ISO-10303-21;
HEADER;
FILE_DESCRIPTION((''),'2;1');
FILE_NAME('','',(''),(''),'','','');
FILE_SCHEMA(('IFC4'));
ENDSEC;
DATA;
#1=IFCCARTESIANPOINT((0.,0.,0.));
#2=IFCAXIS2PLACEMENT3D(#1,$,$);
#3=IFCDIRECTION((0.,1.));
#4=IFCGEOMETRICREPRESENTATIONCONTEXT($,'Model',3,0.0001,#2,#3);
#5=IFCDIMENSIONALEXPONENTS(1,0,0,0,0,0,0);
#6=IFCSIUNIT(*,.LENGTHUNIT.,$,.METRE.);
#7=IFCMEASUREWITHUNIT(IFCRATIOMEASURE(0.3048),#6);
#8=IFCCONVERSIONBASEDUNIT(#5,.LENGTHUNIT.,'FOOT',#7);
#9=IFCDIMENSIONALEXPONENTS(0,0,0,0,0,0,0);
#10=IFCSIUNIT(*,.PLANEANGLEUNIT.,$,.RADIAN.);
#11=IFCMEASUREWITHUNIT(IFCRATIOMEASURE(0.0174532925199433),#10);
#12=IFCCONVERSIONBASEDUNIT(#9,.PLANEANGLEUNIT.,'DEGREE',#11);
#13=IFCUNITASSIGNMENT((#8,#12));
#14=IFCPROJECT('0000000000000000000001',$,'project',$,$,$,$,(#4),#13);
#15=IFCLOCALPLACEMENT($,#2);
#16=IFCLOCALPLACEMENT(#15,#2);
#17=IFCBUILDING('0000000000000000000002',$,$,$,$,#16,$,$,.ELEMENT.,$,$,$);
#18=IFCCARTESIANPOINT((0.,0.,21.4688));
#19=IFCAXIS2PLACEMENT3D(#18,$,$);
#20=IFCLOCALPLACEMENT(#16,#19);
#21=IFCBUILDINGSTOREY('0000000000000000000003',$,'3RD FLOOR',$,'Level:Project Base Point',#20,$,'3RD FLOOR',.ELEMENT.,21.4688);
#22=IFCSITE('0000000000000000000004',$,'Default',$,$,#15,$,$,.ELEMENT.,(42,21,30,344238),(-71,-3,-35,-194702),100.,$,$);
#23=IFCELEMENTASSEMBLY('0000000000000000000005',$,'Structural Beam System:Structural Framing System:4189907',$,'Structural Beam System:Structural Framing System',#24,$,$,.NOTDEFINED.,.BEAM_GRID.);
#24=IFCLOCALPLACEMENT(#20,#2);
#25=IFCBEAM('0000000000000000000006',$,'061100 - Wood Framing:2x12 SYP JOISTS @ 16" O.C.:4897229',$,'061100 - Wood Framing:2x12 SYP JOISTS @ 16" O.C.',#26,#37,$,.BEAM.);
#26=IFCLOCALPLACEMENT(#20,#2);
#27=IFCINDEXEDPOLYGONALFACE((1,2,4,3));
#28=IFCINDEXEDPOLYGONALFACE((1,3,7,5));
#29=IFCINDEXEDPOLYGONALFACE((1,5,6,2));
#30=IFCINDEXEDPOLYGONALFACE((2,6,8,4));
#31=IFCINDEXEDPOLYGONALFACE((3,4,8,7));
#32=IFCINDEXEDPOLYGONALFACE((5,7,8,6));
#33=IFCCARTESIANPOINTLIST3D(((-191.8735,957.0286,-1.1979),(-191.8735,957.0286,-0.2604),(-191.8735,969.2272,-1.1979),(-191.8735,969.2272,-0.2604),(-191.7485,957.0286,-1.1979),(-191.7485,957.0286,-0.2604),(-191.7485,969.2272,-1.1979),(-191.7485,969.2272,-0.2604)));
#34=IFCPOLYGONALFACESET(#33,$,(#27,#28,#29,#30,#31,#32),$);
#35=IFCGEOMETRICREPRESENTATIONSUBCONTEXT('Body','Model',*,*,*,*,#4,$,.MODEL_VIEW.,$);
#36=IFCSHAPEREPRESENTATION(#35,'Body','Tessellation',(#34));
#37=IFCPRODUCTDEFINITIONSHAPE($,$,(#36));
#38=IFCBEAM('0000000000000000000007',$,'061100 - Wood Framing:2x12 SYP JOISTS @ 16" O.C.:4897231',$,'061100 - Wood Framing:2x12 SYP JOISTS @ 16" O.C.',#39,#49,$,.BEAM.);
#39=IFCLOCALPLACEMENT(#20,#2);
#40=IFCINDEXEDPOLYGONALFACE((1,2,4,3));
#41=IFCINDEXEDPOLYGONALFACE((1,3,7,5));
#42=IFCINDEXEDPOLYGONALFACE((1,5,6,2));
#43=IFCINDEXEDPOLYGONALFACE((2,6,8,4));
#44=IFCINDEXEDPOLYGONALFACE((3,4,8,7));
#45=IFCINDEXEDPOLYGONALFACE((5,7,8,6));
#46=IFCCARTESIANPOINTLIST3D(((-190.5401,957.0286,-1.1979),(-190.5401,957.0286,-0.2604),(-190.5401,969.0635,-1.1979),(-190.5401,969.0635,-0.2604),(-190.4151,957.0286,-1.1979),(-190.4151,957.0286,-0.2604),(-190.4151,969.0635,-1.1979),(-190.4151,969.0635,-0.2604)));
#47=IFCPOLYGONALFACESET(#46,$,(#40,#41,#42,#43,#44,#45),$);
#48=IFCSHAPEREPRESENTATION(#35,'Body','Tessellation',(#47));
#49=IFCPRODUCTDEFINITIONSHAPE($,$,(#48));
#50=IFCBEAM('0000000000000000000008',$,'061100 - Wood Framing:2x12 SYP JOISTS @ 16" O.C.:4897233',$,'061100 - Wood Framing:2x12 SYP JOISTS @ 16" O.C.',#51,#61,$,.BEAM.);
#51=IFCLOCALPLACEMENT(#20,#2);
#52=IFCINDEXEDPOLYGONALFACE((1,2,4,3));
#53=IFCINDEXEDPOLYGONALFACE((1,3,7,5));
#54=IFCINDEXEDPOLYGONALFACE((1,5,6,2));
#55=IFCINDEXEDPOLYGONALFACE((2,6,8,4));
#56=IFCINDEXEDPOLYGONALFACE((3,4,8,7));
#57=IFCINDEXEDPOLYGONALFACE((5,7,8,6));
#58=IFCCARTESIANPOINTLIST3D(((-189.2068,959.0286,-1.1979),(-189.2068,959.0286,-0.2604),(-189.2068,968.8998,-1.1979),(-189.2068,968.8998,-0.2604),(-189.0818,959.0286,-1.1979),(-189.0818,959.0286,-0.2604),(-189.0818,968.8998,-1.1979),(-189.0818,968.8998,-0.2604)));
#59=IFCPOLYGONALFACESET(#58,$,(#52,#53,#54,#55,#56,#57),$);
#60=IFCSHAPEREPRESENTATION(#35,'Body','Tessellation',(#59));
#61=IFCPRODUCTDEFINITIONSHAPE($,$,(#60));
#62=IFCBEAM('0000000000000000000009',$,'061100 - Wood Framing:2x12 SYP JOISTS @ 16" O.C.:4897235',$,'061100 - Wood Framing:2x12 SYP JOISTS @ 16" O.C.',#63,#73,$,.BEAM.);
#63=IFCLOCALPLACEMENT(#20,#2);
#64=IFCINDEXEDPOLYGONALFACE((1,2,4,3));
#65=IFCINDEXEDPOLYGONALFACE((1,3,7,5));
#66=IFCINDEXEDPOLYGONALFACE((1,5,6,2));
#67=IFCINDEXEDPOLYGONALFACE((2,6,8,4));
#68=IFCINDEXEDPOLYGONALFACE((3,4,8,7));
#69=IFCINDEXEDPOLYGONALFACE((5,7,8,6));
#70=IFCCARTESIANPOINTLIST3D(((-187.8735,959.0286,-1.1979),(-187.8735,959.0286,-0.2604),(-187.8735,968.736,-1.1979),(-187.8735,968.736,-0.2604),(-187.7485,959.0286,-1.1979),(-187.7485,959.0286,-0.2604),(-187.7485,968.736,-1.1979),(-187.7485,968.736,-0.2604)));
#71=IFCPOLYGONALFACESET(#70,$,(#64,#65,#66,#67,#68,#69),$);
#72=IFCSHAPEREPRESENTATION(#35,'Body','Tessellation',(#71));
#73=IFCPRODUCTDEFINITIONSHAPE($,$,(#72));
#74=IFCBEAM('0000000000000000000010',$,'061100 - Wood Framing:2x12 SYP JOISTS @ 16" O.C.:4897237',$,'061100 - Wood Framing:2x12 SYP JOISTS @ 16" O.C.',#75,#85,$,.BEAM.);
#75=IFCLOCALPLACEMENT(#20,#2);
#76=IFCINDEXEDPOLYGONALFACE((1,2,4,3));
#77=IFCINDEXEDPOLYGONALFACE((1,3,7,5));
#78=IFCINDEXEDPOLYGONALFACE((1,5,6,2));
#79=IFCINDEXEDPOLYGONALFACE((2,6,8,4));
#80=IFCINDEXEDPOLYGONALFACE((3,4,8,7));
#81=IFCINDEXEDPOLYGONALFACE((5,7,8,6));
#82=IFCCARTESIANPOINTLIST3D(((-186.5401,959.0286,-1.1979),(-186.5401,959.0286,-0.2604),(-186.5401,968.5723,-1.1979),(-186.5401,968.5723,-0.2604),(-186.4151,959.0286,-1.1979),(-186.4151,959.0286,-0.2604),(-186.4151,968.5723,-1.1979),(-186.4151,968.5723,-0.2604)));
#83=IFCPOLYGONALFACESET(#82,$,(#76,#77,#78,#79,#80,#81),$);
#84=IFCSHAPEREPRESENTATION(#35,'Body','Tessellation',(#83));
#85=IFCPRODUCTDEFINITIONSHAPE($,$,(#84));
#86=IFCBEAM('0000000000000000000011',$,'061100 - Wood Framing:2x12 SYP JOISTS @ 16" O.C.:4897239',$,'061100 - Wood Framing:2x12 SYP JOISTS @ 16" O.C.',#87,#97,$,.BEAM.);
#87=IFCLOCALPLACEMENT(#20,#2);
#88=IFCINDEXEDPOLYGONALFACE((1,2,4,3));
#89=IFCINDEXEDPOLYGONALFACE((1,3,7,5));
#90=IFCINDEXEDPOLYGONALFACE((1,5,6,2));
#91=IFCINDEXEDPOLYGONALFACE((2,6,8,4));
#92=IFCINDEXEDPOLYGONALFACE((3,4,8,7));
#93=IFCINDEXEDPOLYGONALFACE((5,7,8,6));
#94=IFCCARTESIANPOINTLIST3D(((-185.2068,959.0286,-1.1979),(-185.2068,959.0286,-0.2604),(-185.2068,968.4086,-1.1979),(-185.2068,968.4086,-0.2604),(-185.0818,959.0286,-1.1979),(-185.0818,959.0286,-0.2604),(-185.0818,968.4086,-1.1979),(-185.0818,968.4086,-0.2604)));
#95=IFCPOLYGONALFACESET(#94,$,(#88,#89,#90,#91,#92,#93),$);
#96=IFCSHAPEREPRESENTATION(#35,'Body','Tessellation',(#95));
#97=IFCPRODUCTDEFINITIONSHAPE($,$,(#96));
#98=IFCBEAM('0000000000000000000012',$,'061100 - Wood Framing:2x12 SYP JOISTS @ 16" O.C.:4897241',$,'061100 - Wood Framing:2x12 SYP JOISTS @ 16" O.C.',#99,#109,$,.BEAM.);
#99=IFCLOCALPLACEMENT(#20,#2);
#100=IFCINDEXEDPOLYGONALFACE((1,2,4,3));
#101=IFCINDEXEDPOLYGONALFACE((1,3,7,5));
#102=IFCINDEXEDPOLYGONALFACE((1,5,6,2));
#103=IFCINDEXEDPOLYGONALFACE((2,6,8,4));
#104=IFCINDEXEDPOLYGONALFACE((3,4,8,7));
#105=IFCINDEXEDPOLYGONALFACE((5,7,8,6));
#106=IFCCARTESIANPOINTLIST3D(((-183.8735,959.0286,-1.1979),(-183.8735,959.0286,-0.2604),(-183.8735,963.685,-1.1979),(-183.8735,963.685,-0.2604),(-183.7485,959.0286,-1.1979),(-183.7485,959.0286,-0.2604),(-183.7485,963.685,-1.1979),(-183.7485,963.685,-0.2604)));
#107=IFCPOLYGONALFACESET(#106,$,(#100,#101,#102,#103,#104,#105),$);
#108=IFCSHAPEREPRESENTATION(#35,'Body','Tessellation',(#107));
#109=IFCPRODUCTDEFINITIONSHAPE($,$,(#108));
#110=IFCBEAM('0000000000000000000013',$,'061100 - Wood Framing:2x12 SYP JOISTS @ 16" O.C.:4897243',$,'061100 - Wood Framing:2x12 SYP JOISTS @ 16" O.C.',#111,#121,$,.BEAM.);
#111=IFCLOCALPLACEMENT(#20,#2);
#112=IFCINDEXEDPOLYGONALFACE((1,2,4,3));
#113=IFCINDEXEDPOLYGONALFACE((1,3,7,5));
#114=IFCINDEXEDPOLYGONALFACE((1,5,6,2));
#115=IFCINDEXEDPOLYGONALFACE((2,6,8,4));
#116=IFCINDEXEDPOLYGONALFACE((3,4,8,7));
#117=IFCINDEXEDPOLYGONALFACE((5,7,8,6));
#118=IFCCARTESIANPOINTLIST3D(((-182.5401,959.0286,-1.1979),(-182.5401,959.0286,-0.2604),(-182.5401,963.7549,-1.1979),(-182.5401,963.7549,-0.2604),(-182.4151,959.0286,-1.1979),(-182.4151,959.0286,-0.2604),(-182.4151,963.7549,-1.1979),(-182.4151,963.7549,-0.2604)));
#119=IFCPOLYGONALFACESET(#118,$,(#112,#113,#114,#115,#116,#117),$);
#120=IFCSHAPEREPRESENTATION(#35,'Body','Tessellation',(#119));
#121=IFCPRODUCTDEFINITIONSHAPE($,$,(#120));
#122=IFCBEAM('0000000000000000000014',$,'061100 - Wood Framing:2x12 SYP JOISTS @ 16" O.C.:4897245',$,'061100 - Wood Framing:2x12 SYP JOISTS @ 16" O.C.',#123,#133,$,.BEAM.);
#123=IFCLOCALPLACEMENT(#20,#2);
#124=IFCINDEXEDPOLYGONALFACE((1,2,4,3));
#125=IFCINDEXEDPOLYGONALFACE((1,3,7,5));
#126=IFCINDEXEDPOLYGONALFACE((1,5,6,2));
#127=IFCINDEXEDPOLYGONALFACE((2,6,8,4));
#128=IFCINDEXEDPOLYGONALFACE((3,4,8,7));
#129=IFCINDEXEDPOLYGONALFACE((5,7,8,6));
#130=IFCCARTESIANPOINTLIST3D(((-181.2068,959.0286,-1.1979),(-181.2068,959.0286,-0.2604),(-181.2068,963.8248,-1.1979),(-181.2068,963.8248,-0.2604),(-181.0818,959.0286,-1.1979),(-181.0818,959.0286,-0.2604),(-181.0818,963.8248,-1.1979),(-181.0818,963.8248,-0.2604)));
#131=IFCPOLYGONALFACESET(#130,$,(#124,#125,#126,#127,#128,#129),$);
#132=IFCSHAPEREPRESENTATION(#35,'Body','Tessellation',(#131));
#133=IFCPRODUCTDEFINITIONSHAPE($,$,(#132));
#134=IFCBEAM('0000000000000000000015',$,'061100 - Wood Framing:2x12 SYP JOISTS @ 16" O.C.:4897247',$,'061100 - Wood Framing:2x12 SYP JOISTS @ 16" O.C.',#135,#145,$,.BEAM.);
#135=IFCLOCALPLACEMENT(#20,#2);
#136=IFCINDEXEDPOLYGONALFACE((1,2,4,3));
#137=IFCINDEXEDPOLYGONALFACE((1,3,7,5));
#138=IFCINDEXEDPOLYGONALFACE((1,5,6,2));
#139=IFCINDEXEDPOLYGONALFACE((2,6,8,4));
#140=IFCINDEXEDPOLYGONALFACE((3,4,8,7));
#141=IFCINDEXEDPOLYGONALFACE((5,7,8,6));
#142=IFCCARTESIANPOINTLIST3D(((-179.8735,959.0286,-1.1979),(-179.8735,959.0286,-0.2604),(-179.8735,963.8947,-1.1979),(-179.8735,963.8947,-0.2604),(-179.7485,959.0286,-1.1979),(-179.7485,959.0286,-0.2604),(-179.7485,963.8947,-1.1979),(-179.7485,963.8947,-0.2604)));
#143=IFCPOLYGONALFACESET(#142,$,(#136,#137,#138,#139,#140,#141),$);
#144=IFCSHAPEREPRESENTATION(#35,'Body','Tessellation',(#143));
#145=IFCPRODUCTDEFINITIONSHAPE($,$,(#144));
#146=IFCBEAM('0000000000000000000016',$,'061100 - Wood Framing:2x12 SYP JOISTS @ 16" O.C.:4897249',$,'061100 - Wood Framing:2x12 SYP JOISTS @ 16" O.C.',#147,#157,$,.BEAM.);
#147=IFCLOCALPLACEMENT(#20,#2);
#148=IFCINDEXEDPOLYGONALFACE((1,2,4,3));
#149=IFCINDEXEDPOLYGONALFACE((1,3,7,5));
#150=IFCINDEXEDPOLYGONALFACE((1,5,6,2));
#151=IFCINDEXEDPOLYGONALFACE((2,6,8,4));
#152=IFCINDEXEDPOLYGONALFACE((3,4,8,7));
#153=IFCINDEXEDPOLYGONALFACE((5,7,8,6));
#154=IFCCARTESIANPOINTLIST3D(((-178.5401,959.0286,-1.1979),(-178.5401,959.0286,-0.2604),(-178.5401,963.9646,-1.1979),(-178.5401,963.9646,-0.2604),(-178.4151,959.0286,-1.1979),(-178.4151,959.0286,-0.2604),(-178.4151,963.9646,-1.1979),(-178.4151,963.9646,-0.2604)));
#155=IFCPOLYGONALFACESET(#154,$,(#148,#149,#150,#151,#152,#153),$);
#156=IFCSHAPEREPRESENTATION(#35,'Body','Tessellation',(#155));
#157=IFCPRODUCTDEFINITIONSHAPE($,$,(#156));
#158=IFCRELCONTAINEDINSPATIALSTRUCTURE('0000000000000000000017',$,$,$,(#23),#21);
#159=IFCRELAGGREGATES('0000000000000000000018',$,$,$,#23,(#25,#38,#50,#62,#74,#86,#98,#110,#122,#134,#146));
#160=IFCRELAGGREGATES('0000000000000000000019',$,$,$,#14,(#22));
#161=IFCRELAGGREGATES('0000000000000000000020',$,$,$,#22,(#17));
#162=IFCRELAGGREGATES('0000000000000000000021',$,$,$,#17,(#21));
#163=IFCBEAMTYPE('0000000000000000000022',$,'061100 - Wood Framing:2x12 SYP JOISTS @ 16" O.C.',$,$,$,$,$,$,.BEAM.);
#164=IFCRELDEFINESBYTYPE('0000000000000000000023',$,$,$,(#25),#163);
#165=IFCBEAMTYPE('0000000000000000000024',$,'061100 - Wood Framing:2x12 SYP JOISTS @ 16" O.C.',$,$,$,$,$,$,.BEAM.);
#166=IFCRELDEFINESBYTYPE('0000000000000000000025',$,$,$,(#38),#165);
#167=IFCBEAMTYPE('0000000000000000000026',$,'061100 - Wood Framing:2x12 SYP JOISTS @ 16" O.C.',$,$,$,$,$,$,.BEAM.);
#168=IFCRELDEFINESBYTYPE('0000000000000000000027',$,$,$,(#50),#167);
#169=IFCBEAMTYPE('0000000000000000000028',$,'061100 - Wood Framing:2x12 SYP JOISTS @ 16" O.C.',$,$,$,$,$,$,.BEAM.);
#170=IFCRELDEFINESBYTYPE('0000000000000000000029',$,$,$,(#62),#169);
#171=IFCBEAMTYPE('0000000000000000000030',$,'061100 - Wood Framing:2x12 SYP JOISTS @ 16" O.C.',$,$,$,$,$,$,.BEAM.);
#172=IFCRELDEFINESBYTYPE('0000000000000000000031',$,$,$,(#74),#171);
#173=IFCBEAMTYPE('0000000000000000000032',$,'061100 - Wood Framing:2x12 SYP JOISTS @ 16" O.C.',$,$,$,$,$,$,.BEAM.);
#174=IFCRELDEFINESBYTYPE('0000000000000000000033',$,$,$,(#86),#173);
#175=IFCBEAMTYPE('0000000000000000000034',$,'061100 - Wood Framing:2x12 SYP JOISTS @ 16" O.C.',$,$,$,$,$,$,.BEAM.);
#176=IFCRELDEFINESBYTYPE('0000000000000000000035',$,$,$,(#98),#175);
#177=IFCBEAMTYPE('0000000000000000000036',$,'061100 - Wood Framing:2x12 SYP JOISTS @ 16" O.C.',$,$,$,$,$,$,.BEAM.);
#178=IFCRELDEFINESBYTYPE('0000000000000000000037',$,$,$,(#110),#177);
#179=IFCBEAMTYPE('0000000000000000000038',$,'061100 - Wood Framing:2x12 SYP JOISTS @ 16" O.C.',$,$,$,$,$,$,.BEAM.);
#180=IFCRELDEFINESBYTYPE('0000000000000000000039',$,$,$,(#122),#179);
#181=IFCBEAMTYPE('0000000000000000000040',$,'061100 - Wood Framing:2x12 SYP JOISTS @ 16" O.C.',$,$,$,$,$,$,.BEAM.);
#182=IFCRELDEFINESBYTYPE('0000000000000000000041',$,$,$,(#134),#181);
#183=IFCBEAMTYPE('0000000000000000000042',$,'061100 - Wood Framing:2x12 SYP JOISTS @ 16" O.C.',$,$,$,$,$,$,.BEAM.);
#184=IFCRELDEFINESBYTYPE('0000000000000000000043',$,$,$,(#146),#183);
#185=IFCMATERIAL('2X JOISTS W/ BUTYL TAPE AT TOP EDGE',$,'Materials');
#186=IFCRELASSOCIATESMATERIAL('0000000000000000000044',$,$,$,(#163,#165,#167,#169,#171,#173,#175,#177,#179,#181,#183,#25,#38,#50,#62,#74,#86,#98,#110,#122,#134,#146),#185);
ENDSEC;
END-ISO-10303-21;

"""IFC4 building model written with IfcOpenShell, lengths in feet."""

from ifc_helpers import new_model, entity, si_unit, converted_unit, direction, frame, origin, origin_2d_with_axis, place, context, subcontext, project, spatial, rectangle, extrude, source, transform, mapped, material, material_profile, profile_set, profile_usage, type_object, type_shapes, element, aggregate, save


model = new_model("IFC4")

# Units and contexts
model_context = context("Model", 3, precision=0.0001, world=origin(), true_north=direction((0.0, 1.0)))
body_context = subcontext(model_context, "Body", "Model", "MODEL_VIEW")
ifc_project = project(units=[converted_unit("LENGTHUNIT", "FOOT", entity("IfcRatioMeasure", 0.3048), si_unit("LENGTHUNIT", "METRE"), dimensions=[1, 0, 0, 0, 0, 0, 0]), converted_unit("PLANEANGLEUNIT", "DEGREE", entity("IfcRatioMeasure", 0.0174532925199433), si_unit("PLANEANGLEUNIT", "RADIAN"), dimensions=[0, 0, 0, 0, 0, 0, 0])], contexts=[model_context])

# Site, building, storey
site_placement = place(None, origin())
site = spatial("IfcSite", under=ifc_project, at=site_placement, Name="Default", CompositionType="ELEMENT", RefLatitude=(42, 21, 30, 344238), RefLongitude=(-71, -3, -35, -194702), RefElevation=100.0)
building_placement = place(site_placement, origin())
building = spatial("IfcBuilding", under=site, at=building_placement, CompositionType="ELEMENT")
storey_placement = place(building_placement, frame((0.0, 0.0, 21.4688)))
storey = spatial("IfcBuildingStorey", under=building, at=storey_placement, Name="3RD FLOOR", ObjectType="Level:Project Base Point", LongName="3RD FLOOR", CompositionType="ELEMENT", Elevation=21.4688)

# Element assembly, beams
assembly_1_placement = place(storey_placement, origin())
assembly_1 = element("IfcElementAssembly", 1, at=assembly_1_placement, inside=storey, Name="Structural Beam System:Structural Framing System:4189907", ObjectType="Structural Beam System:Structural Framing System", AssemblyPlace="NOTDEFINED", PredefinedType="BEAM_GRID")
ifc_material_1 = material(Name="2X JOISTS W/ BUTYL TAPE AT TOP EDGE", Category="Materials")
ifc_material_profile_1 = material_profile(ifc_material_1, rectangle(XDim=0.9375, YDim=0.125, at=origin_2d_with_axis()), Name="2x12 SYP JOISTS @ 16\" O.C.")
ifc_profile_set_1 = profile_set([ifc_material_profile_1], Name="2x12 SYP JOISTS @ 16\" O.C.")
ifc_profile_usage_1 = profile_usage(ifc_profile_set_1, cardinal=8)
beam_type_1 = type_object("IfcBeamType", Name="061100 - Wood Framing:2x12 SYP JOISTS @ 16\" O.C.", PredefinedType="BEAM", material=ifc_profile_set_1)
shared_shape_1 = source(origin(), body_context, "Body", "SweptSolid", [
    extrude(rectangle(XDim=0.9375, YDim=0.125, at=origin_2d_with_axis()), frame((-6.0993, 0.0, 0.0), z_axis=(1.0, 0.0, 0.0), x_axis=(0.0, 0.0, -1.0)), (0.0, 0.0, 1.0), 12.1986),
])
type_shapes(beam_type_1, [shared_shape_1])
beam_1_placement = place(assembly_1_placement, frame((-191.811, 963.1279, -0.7292), z_axis=(0.0, 0.0, 1.0), x_axis=(0.0, 1.0, 0.0)))
beam_1 = element("IfcBeam", 2, at=beam_1_placement, type_object=beam_type_1, material=ifc_profile_usage_1, Name="061100 - Wood Framing:2x12 SYP JOISTS @ 16\" O.C.:4897229", ObjectType="061100 - Wood Framing:2x12 SYP JOISTS @ 16\" O.C.", PredefinedType="BEAM", context=body_context, shape_type="MappedRepresentation", body=[
    mapped(shared_shape_1, transform((0.0, 0.0, 0.0), scale=1.0)),
])
ifc_profile_usage_2 = profile_usage(ifc_profile_set_1, cardinal=8)
beam_type_2 = type_object("IfcBeamType", Name="061100 - Wood Framing:2x12 SYP JOISTS @ 16\" O.C.", PredefinedType="BEAM", material=ifc_profile_set_1)
shared_shape_2 = source(origin(), body_context, "Body", "SweptSolid", [
    extrude(rectangle(XDim=0.9375, YDim=0.125, at=origin_2d_with_axis()), frame((-6.0174, 0.0, 0.0), z_axis=(1.0, 0.0, 0.0), x_axis=(0.0, 0.0, -1.0)), (0.0, 0.0, 1.0), 12.0349),
])
type_shapes(beam_type_2, [shared_shape_2])
beam_2_placement = place(assembly_1_placement, frame((-190.4776, 963.046, -0.7292), z_axis=(0.0, 0.0, 1.0), x_axis=(0.0, 1.0, 0.0)))
beam_2 = element("IfcBeam", 3, at=beam_2_placement, type_object=beam_type_2, material=ifc_profile_usage_2, Name="061100 - Wood Framing:2x12 SYP JOISTS @ 16\" O.C.:4897231", ObjectType="061100 - Wood Framing:2x12 SYP JOISTS @ 16\" O.C.", PredefinedType="BEAM", context=body_context, shape_type="MappedRepresentation", body=[
    mapped(shared_shape_2, transform((0.0, 0.0, 0.0), scale=1.0)),
])
ifc_profile_usage_3 = profile_usage(ifc_profile_set_1, cardinal=8)
beam_type_3 = type_object("IfcBeamType", Name="061100 - Wood Framing:2x12 SYP JOISTS @ 16\" O.C.", PredefinedType="BEAM", material=ifc_profile_set_1)
shared_shape_3 = source(origin(), body_context, "Body", "SweptSolid", [
    extrude(rectangle(XDim=0.9375, YDim=0.125, at=origin_2d_with_axis()), frame((-4.9356, 0.0, 0.0), z_axis=(1.0, 0.0, 0.0), x_axis=(0.0, 0.0, -1.0)), (0.0, 0.0, 1.0), 9.8712),
])
type_shapes(beam_type_3, [shared_shape_3])
beam_3_placement = place(assembly_1_placement, frame((-189.1443, 963.9642, -0.7292), z_axis=(0.0, 0.0, 1.0), x_axis=(0.0, 1.0, 0.0)))
beam_3 = element("IfcBeam", 4, at=beam_3_placement, type_object=beam_type_3, material=ifc_profile_usage_3, Name="061100 - Wood Framing:2x12 SYP JOISTS @ 16\" O.C.:4897233", ObjectType="061100 - Wood Framing:2x12 SYP JOISTS @ 16\" O.C.", PredefinedType="BEAM", context=body_context, shape_type="MappedRepresentation", body=[
    mapped(shared_shape_3, transform((0.0, 0.0, 0.0), scale=1.0)),
])
ifc_profile_usage_4 = profile_usage(ifc_profile_set_1, cardinal=8)
beam_type_4 = type_object("IfcBeamType", Name="061100 - Wood Framing:2x12 SYP JOISTS @ 16\" O.C.", PredefinedType="BEAM", material=ifc_profile_set_1)
shared_shape_4 = source(origin(), body_context, "Body", "SweptSolid", [
    extrude(rectangle(XDim=0.9375, YDim=0.125, at=origin_2d_with_axis()), frame((-4.8537, 0.0, 0.0), z_axis=(1.0, 0.0, 0.0), x_axis=(0.0, 0.0, -1.0)), (0.0, 0.0, 1.0), 9.7074),
])
type_shapes(beam_type_4, [shared_shape_4])
beam_4_placement = place(assembly_1_placement, frame((-187.811, 963.8823, -0.7292), z_axis=(0.0, 0.0, 1.0), x_axis=(0.0, 1.0, 0.0)))
beam_4 = element("IfcBeam", 5, at=beam_4_placement, type_object=beam_type_4, material=ifc_profile_usage_4, Name="061100 - Wood Framing:2x12 SYP JOISTS @ 16\" O.C.:4897235", ObjectType="061100 - Wood Framing:2x12 SYP JOISTS @ 16\" O.C.", PredefinedType="BEAM", context=body_context, shape_type="MappedRepresentation", body=[
    mapped(shared_shape_4, transform((0.0, 0.0, 0.0), scale=1.0)),
])
ifc_profile_usage_5 = profile_usage(ifc_profile_set_1, cardinal=8)
beam_type_5 = type_object("IfcBeamType", Name="061100 - Wood Framing:2x12 SYP JOISTS @ 16\" O.C.", PredefinedType="BEAM", material=ifc_profile_set_1)
shared_shape_5 = source(origin(), body_context, "Body", "SweptSolid", [
    extrude(rectangle(XDim=0.9375, YDim=0.125, at=origin_2d_with_axis()), frame((-4.7719, 0.0, 0.0), z_axis=(1.0, 0.0, 0.0), x_axis=(0.0, 0.0, -1.0)), (0.0, 0.0, 1.0), 9.5437),
])
type_shapes(beam_type_5, [shared_shape_5])
beam_5_placement = place(assembly_1_placement, frame((-186.4776, 963.8005, -0.7292), z_axis=(0.0, 0.0, 1.0), x_axis=(0.0, 1.0, 0.0)))
beam_5 = element("IfcBeam", 6, at=beam_5_placement, type_object=beam_type_5, material=ifc_profile_usage_5, Name="061100 - Wood Framing:2x12 SYP JOISTS @ 16\" O.C.:4897237", ObjectType="061100 - Wood Framing:2x12 SYP JOISTS @ 16\" O.C.", PredefinedType="BEAM", context=body_context, shape_type="MappedRepresentation", body=[
    mapped(shared_shape_5, transform((0.0, 0.0, 0.0), scale=1.0)),
])
ifc_profile_usage_6 = profile_usage(ifc_profile_set_1, cardinal=8)
beam_type_6 = type_object("IfcBeamType", Name="061100 - Wood Framing:2x12 SYP JOISTS @ 16\" O.C.", PredefinedType="BEAM", material=ifc_profile_set_1)
shared_shape_6 = source(origin(), body_context, "Body", "SweptSolid", [
    extrude(rectangle(XDim=0.9375, YDim=0.125, at=origin_2d_with_axis()), frame((-4.69, 0.0, 0.0), z_axis=(1.0, 0.0, 0.0), x_axis=(0.0, 0.0, -1.0)), (0.0, 0.0, 1.0), 9.38),
])
type_shapes(beam_type_6, [shared_shape_6])
beam_6_placement = place(assembly_1_placement, frame((-185.1443, 963.7186, -0.7292), z_axis=(0.0, 0.0, 1.0), x_axis=(0.0, 1.0, 0.0)))
beam_6 = element("IfcBeam", 7, at=beam_6_placement, type_object=beam_type_6, material=ifc_profile_usage_6, Name="061100 - Wood Framing:2x12 SYP JOISTS @ 16\" O.C.:4897239", ObjectType="061100 - Wood Framing:2x12 SYP JOISTS @ 16\" O.C.", PredefinedType="BEAM", context=body_context, shape_type="MappedRepresentation", body=[
    mapped(shared_shape_6, transform((0.0, 0.0, 0.0), scale=1.0)),
])
ifc_profile_usage_7 = profile_usage(ifc_profile_set_1, cardinal=8)
beam_type_7 = type_object("IfcBeamType", Name="061100 - Wood Framing:2x12 SYP JOISTS @ 16\" O.C.", PredefinedType="BEAM", material=ifc_profile_set_1)
shared_shape_7 = source(origin(), body_context, "Body", "SweptSolid", [
    extrude(rectangle(XDim=0.9375, YDim=0.125, at=origin_2d_with_axis()), frame((-2.3282, 0.0, 0.0), z_axis=(1.0, 0.0, 0.0), x_axis=(0.0, 0.0, -1.0)), (0.0, 0.0, 1.0), 4.6564),
])
type_shapes(beam_type_7, [shared_shape_7])
beam_7_placement = place(assembly_1_placement, frame((-183.811, 961.3568, -0.7292), z_axis=(0.0, 0.0, 1.0), x_axis=(0.0, 1.0, 0.0)))
beam_7 = element("IfcBeam", 8, at=beam_7_placement, type_object=beam_type_7, material=ifc_profile_usage_7, Name="061100 - Wood Framing:2x12 SYP JOISTS @ 16\" O.C.:4897241", ObjectType="061100 - Wood Framing:2x12 SYP JOISTS @ 16\" O.C.", PredefinedType="BEAM", context=body_context, shape_type="MappedRepresentation", body=[
    mapped(shared_shape_7, transform((0.0, 0.0, 0.0), scale=1.0)),
])
ifc_profile_usage_8 = profile_usage(ifc_profile_set_1, cardinal=8)
beam_type_8 = type_object("IfcBeamType", Name="061100 - Wood Framing:2x12 SYP JOISTS @ 16\" O.C.", PredefinedType="BEAM", material=ifc_profile_set_1)
shared_shape_8 = source(origin(), body_context, "Body", "SweptSolid", [
    extrude(rectangle(XDim=0.9375, YDim=0.125, at=origin_2d_with_axis()), frame((-2.3632, 0.0, 0.0), z_axis=(1.0, 0.0, 0.0), x_axis=(0.0, 0.0, -1.0)), (0.0, 0.0, 1.0), 4.7263),
])
type_shapes(beam_type_8, [shared_shape_8])
beam_8_placement = place(assembly_1_placement, frame((-182.4776, 961.3918, -0.7292), z_axis=(0.0, 0.0, 1.0), x_axis=(0.0, 1.0, 0.0)))
beam_8 = element("IfcBeam", 9, at=beam_8_placement, type_object=beam_type_8, material=ifc_profile_usage_8, Name="061100 - Wood Framing:2x12 SYP JOISTS @ 16\" O.C.:4897243", ObjectType="061100 - Wood Framing:2x12 SYP JOISTS @ 16\" O.C.", PredefinedType="BEAM", context=body_context, shape_type="MappedRepresentation", body=[
    mapped(shared_shape_8, transform((0.0, 0.0, 0.0), scale=1.0)),
])
ifc_profile_usage_9 = profile_usage(ifc_profile_set_1, cardinal=8)
beam_type_9 = type_object("IfcBeamType", Name="061100 - Wood Framing:2x12 SYP JOISTS @ 16\" O.C.", PredefinedType="BEAM", material=ifc_profile_set_1)
shared_shape_9 = source(origin(), body_context, "Body", "SweptSolid", [
    extrude(rectangle(XDim=0.9375, YDim=0.125, at=origin_2d_with_axis()), frame((-2.3981, 0.0, 0.0), z_axis=(1.0, 0.0, 0.0), x_axis=(0.0, 0.0, -1.0)), (0.0, 0.0, 1.0), 4.7962),
])
type_shapes(beam_type_9, [shared_shape_9])
beam_9_placement = place(assembly_1_placement, frame((-181.1443, 961.4267, -0.7292), z_axis=(0.0, 0.0, 1.0), x_axis=(0.0, 1.0, 0.0)))
beam_9 = element("IfcBeam", 10, at=beam_9_placement, type_object=beam_type_9, material=ifc_profile_usage_9, Name="061100 - Wood Framing:2x12 SYP JOISTS @ 16\" O.C.:4897245", ObjectType="061100 - Wood Framing:2x12 SYP JOISTS @ 16\" O.C.", PredefinedType="BEAM", context=body_context, shape_type="MappedRepresentation", body=[
    mapped(shared_shape_9, transform((0.0, 0.0, 0.0), scale=1.0)),
])
ifc_profile_usage_10 = profile_usage(ifc_profile_set_1, cardinal=8)
beam_type_10 = type_object("IfcBeamType", Name="061100 - Wood Framing:2x12 SYP JOISTS @ 16\" O.C.", PredefinedType="BEAM", material=ifc_profile_set_1)
shared_shape_10 = source(origin(), body_context, "Body", "SweptSolid", [
    extrude(rectangle(XDim=0.9375, YDim=0.125, at=origin_2d_with_axis()), frame((-2.433, 0.0, 0.0), z_axis=(1.0, 0.0, 0.0), x_axis=(0.0, 0.0, -1.0)), (0.0, 0.0, 1.0), 4.8661),
])
type_shapes(beam_type_10, [shared_shape_10])
beam_10_placement = place(assembly_1_placement, frame((-179.811, 961.4616, -0.7292), z_axis=(0.0, 0.0, 1.0), x_axis=(0.0, 1.0, 0.0)))
beam_10 = element("IfcBeam", 11, at=beam_10_placement, type_object=beam_type_10, material=ifc_profile_usage_10, Name="061100 - Wood Framing:2x12 SYP JOISTS @ 16\" O.C.:4897247", ObjectType="061100 - Wood Framing:2x12 SYP JOISTS @ 16\" O.C.", PredefinedType="BEAM", context=body_context, shape_type="MappedRepresentation", body=[
    mapped(shared_shape_10, transform((0.0, 0.0, 0.0), scale=1.0)),
])
ifc_profile_usage_11 = profile_usage(ifc_profile_set_1, cardinal=8)
beam_type_11 = type_object("IfcBeamType", Name="061100 - Wood Framing:2x12 SYP JOISTS @ 16\" O.C.", PredefinedType="BEAM", material=ifc_profile_set_1)
shared_shape_11 = source(origin(), body_context, "Body", "SweptSolid", [
    extrude(rectangle(XDim=0.9375, YDim=0.125, at=origin_2d_with_axis()), frame((-2.468, 0.0, 0.0), z_axis=(1.0, 0.0, 0.0), x_axis=(0.0, 0.0, -1.0)), (0.0, 0.0, 1.0), 4.936),
])
type_shapes(beam_type_11, [shared_shape_11])
beam_11_placement = place(assembly_1_placement, frame((-178.4776, 961.4966, -0.7292), z_axis=(0.0, 0.0, 1.0), x_axis=(0.0, 1.0, 0.0)))
beam_11 = element("IfcBeam", 12, at=beam_11_placement, type_object=beam_type_11, material=ifc_profile_usage_11, Name="061100 - Wood Framing:2x12 SYP JOISTS @ 16\" O.C.:4897249", ObjectType="061100 - Wood Framing:2x12 SYP JOISTS @ 16\" O.C.", PredefinedType="BEAM", context=body_context, shape_type="MappedRepresentation", body=[
    mapped(shared_shape_11, transform((0.0, 0.0, 0.0), scale=1.0)),
])
aggregate(assembly_1, [beam_1, beam_2, beam_3, beam_4, beam_5, beam_6, beam_7, beam_8, beam_9, beam_10, beam_11])

save(model, "model.ifc")
